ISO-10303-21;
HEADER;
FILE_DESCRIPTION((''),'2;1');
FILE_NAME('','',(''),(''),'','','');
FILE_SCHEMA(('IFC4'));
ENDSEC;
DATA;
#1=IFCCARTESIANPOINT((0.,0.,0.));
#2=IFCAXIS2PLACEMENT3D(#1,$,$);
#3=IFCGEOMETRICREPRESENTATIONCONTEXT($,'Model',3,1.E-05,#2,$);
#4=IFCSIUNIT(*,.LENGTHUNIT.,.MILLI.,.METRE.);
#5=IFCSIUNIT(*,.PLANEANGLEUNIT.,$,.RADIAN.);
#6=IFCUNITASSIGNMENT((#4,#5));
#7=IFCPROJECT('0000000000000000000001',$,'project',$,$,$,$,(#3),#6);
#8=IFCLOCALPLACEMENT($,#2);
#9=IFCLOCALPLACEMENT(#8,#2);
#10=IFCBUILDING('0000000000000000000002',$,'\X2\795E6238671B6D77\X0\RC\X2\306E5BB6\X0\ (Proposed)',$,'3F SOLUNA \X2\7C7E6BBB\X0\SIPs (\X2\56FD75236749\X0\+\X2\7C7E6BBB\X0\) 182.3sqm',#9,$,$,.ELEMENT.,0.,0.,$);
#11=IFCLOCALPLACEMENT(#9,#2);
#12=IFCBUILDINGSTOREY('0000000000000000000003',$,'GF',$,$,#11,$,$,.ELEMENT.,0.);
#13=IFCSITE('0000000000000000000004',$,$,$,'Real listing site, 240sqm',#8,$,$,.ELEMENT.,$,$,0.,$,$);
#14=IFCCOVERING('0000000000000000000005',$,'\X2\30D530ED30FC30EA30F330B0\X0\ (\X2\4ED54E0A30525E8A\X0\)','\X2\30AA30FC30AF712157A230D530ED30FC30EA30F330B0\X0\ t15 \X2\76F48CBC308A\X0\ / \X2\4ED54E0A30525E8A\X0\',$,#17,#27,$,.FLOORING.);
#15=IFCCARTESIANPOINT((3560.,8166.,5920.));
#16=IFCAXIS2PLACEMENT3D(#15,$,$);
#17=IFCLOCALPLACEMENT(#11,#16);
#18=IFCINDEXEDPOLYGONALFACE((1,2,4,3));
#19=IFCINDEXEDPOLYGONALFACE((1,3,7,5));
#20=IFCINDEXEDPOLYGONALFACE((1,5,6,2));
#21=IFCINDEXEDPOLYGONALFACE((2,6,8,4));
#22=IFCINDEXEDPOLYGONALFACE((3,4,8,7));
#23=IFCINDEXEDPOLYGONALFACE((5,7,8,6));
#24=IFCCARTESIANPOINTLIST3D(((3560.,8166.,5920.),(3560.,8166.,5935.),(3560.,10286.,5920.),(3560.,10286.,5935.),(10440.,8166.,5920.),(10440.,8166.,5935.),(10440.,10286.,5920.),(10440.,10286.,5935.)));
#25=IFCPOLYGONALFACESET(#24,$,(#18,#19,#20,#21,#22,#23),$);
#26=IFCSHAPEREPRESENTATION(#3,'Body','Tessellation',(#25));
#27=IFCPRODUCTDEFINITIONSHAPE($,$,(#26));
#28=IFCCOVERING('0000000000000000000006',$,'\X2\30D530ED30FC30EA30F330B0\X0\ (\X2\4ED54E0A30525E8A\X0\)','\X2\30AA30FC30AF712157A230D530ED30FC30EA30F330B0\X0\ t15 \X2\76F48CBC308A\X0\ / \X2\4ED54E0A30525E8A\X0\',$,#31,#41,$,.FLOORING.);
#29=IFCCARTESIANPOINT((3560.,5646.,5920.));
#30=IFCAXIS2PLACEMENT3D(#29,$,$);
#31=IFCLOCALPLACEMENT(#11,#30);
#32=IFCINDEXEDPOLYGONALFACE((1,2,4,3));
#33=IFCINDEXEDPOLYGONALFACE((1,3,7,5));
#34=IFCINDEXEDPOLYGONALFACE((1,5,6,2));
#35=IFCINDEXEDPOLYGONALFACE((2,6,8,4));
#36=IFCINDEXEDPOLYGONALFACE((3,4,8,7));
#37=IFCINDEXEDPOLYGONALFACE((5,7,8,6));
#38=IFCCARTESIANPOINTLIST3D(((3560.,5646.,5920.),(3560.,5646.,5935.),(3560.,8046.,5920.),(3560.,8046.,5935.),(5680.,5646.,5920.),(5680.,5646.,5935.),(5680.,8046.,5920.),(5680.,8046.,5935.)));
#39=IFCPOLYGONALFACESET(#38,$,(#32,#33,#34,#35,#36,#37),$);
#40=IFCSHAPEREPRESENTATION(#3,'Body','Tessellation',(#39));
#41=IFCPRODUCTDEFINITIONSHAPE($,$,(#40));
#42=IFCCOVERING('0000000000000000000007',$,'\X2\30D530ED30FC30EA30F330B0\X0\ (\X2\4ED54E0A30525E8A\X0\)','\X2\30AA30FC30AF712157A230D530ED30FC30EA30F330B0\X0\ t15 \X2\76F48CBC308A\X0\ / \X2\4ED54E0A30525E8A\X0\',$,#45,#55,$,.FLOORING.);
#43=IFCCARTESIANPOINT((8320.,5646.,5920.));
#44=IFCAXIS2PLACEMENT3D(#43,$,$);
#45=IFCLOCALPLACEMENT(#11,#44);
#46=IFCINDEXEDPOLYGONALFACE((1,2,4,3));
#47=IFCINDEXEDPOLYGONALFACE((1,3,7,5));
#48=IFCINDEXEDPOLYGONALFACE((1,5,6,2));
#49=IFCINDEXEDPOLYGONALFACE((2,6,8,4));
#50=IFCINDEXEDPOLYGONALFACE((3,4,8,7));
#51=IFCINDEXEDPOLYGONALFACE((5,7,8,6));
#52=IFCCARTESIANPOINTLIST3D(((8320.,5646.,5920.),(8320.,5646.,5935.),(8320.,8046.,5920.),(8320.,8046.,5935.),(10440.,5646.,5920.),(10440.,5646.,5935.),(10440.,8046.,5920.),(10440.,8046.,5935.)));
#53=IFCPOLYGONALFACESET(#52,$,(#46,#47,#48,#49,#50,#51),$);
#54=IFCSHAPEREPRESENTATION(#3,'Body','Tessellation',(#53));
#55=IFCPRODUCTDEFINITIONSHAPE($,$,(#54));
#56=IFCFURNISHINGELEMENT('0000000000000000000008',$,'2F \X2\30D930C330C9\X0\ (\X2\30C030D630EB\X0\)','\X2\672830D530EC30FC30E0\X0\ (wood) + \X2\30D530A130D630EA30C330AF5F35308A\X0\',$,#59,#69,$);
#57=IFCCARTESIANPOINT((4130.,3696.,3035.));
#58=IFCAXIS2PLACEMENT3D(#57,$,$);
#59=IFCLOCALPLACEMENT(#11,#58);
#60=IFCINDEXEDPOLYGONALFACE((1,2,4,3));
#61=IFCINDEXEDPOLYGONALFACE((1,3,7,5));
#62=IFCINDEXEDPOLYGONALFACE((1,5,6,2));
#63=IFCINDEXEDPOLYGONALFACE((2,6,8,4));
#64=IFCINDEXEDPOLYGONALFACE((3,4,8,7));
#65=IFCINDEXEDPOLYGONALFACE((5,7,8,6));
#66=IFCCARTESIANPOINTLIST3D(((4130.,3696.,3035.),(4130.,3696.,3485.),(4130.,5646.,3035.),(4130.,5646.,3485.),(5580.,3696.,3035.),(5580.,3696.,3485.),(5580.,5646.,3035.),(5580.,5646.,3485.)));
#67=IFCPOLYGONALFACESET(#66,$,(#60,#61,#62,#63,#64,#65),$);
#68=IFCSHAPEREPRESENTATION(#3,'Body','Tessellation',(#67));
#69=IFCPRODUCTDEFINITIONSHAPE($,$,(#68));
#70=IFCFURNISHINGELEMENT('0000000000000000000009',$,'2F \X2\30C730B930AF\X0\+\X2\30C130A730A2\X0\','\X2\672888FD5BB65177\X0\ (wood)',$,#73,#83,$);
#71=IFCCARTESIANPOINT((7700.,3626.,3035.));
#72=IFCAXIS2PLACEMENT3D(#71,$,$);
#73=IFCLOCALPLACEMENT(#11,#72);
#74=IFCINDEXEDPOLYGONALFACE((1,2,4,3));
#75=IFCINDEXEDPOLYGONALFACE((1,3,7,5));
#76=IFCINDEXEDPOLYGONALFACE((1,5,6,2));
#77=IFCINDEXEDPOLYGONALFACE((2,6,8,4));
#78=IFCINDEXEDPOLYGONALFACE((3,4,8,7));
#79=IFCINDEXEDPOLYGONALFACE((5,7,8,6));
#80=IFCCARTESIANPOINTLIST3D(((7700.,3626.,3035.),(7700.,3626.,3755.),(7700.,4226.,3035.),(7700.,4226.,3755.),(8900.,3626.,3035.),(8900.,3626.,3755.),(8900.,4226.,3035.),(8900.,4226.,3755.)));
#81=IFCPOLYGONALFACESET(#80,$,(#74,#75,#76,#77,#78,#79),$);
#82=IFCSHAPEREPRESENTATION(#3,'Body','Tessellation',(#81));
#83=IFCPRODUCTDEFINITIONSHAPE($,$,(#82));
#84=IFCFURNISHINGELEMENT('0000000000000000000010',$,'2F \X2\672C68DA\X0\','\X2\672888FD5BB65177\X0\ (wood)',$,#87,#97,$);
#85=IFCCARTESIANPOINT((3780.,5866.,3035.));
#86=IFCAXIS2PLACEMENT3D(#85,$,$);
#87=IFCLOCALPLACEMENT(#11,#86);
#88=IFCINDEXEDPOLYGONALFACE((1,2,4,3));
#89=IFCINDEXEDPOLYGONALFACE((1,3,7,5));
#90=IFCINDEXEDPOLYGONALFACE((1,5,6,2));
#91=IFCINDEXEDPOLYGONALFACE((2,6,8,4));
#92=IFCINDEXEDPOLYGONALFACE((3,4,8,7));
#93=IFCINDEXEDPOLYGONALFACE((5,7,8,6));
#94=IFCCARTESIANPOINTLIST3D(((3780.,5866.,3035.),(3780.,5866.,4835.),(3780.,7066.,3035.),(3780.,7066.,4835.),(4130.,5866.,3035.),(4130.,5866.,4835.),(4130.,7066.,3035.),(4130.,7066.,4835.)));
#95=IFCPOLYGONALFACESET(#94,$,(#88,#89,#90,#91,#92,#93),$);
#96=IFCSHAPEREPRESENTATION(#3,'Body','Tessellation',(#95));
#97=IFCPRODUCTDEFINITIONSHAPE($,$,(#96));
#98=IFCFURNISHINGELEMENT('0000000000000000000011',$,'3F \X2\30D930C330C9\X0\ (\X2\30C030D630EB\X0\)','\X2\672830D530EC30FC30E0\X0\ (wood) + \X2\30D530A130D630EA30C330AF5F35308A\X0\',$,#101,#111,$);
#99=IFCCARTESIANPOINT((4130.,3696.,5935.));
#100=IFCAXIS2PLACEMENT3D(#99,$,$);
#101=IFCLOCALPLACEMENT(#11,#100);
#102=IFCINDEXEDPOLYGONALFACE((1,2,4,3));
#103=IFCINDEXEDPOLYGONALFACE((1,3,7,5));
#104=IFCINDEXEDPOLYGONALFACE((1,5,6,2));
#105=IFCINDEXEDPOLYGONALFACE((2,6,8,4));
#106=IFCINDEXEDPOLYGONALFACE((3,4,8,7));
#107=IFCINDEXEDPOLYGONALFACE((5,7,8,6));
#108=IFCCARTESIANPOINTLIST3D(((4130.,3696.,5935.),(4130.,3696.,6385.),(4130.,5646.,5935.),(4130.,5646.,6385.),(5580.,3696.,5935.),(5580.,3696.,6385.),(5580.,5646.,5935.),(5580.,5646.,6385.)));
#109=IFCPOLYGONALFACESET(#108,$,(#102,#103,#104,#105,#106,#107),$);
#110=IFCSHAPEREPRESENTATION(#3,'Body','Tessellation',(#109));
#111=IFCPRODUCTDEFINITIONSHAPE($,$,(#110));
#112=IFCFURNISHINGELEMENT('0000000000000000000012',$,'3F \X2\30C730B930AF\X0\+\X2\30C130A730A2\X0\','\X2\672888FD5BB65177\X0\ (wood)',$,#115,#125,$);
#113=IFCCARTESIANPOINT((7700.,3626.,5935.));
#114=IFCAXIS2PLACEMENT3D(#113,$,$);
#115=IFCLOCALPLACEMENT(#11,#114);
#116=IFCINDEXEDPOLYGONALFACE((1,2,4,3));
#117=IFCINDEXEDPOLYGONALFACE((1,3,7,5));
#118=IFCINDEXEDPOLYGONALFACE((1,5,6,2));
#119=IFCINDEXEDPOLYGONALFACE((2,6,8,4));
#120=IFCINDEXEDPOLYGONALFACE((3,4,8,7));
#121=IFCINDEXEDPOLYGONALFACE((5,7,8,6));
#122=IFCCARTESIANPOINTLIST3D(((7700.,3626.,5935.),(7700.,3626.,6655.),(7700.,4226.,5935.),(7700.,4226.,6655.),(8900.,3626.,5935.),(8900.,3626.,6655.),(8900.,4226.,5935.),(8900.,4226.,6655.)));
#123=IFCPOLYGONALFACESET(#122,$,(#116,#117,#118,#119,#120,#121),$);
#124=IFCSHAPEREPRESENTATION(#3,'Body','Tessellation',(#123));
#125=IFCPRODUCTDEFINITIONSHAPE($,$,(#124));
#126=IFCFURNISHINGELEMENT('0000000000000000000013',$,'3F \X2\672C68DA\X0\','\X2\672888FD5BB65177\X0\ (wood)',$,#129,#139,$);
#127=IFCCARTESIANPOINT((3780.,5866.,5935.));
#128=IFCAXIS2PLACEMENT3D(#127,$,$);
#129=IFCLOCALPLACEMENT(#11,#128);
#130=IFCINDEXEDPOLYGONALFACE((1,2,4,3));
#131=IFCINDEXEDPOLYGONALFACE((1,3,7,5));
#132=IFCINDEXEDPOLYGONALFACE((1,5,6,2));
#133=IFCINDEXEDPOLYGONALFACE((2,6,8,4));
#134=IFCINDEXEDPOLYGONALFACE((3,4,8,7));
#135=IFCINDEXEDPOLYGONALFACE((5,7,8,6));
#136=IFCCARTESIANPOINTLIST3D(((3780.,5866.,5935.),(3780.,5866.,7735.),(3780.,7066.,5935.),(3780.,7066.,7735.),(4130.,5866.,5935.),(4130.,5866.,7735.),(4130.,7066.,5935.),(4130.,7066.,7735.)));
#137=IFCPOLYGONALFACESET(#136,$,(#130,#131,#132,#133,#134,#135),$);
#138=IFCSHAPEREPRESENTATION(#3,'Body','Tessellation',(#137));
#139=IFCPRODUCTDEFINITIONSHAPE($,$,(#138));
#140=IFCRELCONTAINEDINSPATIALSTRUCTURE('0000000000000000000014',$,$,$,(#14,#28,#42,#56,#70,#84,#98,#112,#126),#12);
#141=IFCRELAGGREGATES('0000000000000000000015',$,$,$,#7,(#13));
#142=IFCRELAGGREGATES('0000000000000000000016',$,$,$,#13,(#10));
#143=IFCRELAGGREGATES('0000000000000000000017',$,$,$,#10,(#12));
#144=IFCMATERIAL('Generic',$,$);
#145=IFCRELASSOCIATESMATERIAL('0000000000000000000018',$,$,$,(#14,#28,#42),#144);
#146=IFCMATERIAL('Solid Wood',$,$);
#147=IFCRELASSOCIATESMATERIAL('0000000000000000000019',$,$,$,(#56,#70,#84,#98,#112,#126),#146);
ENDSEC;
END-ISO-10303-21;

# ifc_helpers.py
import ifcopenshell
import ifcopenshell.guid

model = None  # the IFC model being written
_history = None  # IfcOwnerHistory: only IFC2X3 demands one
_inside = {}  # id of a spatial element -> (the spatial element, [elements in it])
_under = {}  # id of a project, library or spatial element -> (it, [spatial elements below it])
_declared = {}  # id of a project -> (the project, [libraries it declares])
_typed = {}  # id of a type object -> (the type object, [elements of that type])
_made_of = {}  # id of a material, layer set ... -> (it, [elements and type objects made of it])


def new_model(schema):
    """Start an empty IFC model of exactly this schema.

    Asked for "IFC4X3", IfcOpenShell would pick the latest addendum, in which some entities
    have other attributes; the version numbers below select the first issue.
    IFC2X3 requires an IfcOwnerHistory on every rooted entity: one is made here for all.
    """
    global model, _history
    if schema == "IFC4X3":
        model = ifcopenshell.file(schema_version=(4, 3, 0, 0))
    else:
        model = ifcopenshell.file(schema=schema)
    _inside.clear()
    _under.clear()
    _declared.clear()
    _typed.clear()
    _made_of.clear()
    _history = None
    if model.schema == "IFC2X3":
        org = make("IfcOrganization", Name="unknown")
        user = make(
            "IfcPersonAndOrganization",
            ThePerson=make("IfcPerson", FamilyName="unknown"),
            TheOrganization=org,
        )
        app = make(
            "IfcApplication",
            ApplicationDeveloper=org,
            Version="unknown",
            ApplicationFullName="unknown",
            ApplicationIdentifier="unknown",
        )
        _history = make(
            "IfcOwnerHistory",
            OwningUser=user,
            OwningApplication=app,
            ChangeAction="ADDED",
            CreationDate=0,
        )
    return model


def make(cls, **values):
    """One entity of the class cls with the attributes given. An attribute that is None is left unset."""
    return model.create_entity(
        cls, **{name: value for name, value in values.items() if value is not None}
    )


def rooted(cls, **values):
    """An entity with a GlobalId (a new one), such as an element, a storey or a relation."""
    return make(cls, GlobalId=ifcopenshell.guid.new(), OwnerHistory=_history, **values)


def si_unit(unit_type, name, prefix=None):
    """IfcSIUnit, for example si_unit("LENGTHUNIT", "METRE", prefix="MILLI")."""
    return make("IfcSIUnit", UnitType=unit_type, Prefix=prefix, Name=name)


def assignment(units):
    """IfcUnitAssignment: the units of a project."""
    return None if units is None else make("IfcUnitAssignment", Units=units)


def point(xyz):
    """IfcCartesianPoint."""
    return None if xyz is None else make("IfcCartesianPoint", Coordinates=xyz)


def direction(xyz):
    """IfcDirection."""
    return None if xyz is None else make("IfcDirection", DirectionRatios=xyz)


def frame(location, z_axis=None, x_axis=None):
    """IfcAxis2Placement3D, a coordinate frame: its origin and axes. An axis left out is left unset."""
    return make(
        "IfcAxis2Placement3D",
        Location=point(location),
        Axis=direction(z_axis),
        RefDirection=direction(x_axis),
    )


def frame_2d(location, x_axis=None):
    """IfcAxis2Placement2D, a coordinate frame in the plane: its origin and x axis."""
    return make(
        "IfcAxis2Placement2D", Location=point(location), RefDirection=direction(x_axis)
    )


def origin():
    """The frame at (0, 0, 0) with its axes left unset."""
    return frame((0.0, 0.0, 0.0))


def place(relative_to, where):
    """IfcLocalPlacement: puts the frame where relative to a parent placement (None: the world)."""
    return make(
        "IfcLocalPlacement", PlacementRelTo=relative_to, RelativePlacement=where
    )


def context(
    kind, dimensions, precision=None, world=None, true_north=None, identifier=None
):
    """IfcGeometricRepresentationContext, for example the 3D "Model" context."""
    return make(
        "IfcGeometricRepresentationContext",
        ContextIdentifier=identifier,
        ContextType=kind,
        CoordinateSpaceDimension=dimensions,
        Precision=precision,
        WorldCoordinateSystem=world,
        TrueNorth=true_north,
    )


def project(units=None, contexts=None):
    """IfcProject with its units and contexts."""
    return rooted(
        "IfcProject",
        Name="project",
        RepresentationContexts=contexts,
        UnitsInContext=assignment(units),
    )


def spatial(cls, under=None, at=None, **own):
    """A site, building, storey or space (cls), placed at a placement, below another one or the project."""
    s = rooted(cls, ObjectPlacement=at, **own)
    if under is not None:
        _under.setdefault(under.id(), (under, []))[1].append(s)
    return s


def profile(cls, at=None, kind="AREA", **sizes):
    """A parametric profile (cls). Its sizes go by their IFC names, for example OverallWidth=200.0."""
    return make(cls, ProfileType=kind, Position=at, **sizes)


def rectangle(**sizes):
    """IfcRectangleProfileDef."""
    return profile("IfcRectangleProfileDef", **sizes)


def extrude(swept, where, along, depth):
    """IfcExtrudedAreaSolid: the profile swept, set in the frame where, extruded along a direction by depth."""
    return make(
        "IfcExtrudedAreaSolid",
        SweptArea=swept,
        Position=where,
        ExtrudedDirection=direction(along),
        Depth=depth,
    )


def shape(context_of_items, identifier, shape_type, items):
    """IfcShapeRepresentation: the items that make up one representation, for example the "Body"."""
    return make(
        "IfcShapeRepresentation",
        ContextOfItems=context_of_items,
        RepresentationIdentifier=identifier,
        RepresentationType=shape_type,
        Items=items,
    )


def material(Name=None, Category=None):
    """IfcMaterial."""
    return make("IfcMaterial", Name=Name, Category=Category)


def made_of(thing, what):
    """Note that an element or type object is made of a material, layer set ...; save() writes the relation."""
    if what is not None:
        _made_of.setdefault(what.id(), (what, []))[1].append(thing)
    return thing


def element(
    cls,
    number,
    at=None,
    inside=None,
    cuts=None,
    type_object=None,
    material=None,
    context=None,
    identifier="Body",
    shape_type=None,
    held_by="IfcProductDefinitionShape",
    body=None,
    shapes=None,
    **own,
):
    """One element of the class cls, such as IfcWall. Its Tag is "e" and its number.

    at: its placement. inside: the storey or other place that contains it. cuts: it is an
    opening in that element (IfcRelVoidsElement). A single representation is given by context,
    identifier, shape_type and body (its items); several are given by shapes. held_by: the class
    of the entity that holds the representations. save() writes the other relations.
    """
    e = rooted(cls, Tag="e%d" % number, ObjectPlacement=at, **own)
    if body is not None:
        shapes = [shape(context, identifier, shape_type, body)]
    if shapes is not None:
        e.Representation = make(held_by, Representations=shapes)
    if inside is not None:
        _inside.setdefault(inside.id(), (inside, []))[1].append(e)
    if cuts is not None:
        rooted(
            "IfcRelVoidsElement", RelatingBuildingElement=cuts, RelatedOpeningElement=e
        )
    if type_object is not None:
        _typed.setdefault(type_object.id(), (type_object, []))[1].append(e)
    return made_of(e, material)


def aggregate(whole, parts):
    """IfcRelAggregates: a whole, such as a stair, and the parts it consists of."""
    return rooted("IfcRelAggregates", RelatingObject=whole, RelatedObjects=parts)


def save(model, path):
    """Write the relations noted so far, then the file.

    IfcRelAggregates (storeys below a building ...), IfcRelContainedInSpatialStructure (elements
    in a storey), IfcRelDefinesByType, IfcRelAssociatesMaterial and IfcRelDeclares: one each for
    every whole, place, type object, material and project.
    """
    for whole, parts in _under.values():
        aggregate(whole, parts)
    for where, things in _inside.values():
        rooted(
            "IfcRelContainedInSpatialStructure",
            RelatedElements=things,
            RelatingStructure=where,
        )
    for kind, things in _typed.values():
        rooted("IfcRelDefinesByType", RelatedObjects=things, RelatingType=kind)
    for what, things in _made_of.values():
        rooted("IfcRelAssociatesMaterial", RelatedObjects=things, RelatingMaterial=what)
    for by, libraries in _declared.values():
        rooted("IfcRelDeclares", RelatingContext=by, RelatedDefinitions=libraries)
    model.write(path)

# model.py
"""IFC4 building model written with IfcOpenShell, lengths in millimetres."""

from ifc_helpers import new_model, si_unit, frame, frame_2d, origin, place, context, project, spatial, rectangle, extrude, material, element, save


model = new_model("IFC4")

# Units and contexts
model_context = context("Model", 3, precision=1e-05, world=origin())
ifc_project = project(units=[si_unit("LENGTHUNIT", "METRE", prefix="MILLI"), si_unit("PLANEANGLEUNIT", "RADIAN")], contexts=[model_context])

# Site, building, storey
site_placement = place(None, origin())
site = spatial("IfcSite", under=ifc_project, at=site_placement, ObjectType="Real listing site, 240sqm", CompositionType="ELEMENT", RefElevation=0.0)
building_placement = place(site_placement, origin())
building = spatial("IfcBuilding", under=site, at=building_placement, Name="神戸望海RCの家 (Proposed)", ObjectType="3F SOLUNA 籾殻SIPs (国産杉+籾殻) 182.3sqm", CompositionType="ELEMENT", ElevationOfRefHeight=0.0, ElevationOfTerrain=0.0)
storey_placement = place(building_placement, origin())
storey = spatial("IfcBuildingStorey", under=building, at=storey_placement, Name="GF", CompositionType="ELEMENT", Elevation=0.0)

# Shared definitions
ifc_material_1 = material(Name="Solid Wood")

# Shared definitions
ifc_material_2 = material(Name="Generic")

# Coverings
covering_1_placement = place(storey_placement, frame((3560.0, 8166.0, 5920.0)))
element("IfcCovering", 1, at=covering_1_placement, inside=storey, material=ifc_material_2, Name="フローリング (仕上げ床)", Description="オーク無垢フローリング t15 直貼り / 仕上げ床", PredefinedType="FLOORING", context=model_context, shape_type="SweptSolid", body=[
    extrude(rectangle(XDim=6880.0, YDim=2120.0, at=frame_2d((3440.0, 1060.0))), frame((3560.0, 8166.0, 5920.0)), (0.0, 0.0, 1.0), 15.0),
])
covering_2_placement = place(storey_placement, frame((3560.0, 5646.0, 5920.0)))
element("IfcCovering", 2, at=covering_2_placement, inside=storey, material=ifc_material_2, Name="フローリング (仕上げ床)", Description="オーク無垢フローリング t15 直貼り / 仕上げ床", PredefinedType="FLOORING", context=model_context, shape_type="SweptSolid", body=[
    extrude(rectangle(XDim=2120.0, YDim=2400.0, at=frame_2d((1060.0, 1200.0))), frame((3560.0, 5646.0, 5920.0)), (0.0, 0.0, 1.0), 15.0),
])
covering_3_placement = place(storey_placement, frame((8320.0, 5646.0, 5920.0)))
element("IfcCovering", 3, at=covering_3_placement, inside=storey, material=ifc_material_2, Name="フローリング (仕上げ床)", Description="オーク無垢フローリング t15 直貼り / 仕上げ床", PredefinedType="FLOORING", context=model_context, shape_type="SweptSolid", body=[
    extrude(rectangle(XDim=2120.0, YDim=2400.0, at=frame_2d((1060.0, 1200.0))), frame((8320.0, 5646.0, 5920.0)), (0.0, 0.0, 1.0), 15.0),
])

# Furnishing elements
furnishing_1_placement = place(storey_placement, frame((4130.0, 3696.0, 3035.0)))
element("IfcFurnishingElement", 4, at=furnishing_1_placement, inside=storey, material=ifc_material_1, Name="2F ベッド (ダブル)", Description="木フレーム (wood) + ファブリック張り", context=model_context, shape_type="SweptSolid", body=[
    extrude(rectangle(XDim=1450.0, YDim=1950.0, at=frame_2d((725.0, 975.0))), frame((4130.0, 3696.0, 3035.0)), (0.0, 0.0, 1.0), 450.0),
])
furnishing_2_placement = place(storey_placement, frame((7700.0, 3626.0, 3035.0)))
element("IfcFurnishingElement", 5, at=furnishing_2_placement, inside=storey, material=ifc_material_1, Name="2F デスク+チェア", Description="木製家具 (wood)", context=model_context, shape_type="SweptSolid", body=[
    extrude(rectangle(XDim=1200.0, YDim=600.0, at=frame_2d((600.0, 300.0))), frame((7700.0, 3626.0, 3035.0)), (0.0, 0.0, 1.0), 720.0),
])
furnishing_3_placement = place(storey_placement, frame((3780.0, 5866.0, 3035.0)))
element("IfcFurnishingElement", 6, at=furnishing_3_placement, inside=storey, material=ifc_material_1, Name="2F 本棚", Description="木製家具 (wood)", context=model_context, shape_type="SweptSolid", body=[
    extrude(rectangle(XDim=350.0, YDim=1200.0, at=frame_2d((175.0, 600.0))), frame((3780.0, 5866.0, 3035.0)), (0.0, 0.0, 1.0), 1800.0),
])
furnishing_4_placement = place(storey_placement, frame((4130.0, 3696.0, 5935.0)))
element("IfcFurnishingElement", 7, at=furnishing_4_placement, inside=storey, material=ifc_material_1, Name="3F ベッド (ダブル)", Description="木フレーム (wood) + ファブリック張り", context=model_context, shape_type="SweptSolid", body=[
    extrude(rectangle(XDim=1450.0, YDim=1950.0, at=frame_2d((725.0, 975.0))), frame((4130.0, 3696.0, 5935.0)), (0.0, 0.0, 1.0), 450.0),
])
furnishing_5_placement = place(storey_placement, frame((7700.0, 3626.0, 5935.0)))
element("IfcFurnishingElement", 8, at=furnishing_5_placement, inside=storey, material=ifc_material_1, Name="3F デスク+チェア", Description="木製家具 (wood)", context=model_context, shape_type="SweptSolid", body=[
    extrude(rectangle(XDim=1200.0, YDim=600.0, at=frame_2d((600.0, 300.0))), frame((7700.0, 3626.0, 5935.0)), (0.0, 0.0, 1.0), 720.0),
])
furnishing_6_placement = place(storey_placement, frame((3780.0, 5866.0, 5935.0)))
element("IfcFurnishingElement", 9, at=furnishing_6_placement, inside=storey, material=ifc_material_1, Name="3F 本棚", Description="木製家具 (wood)", context=model_context, shape_type="SweptSolid", body=[
    extrude(rectangle(XDim=350.0, YDim=1200.0, at=frame_2d((175.0, 600.0))), frame((3780.0, 5866.0, 5935.0)), (0.0, 0.0, 1.0), 1800.0),
])

save(model, "model.ifc")
